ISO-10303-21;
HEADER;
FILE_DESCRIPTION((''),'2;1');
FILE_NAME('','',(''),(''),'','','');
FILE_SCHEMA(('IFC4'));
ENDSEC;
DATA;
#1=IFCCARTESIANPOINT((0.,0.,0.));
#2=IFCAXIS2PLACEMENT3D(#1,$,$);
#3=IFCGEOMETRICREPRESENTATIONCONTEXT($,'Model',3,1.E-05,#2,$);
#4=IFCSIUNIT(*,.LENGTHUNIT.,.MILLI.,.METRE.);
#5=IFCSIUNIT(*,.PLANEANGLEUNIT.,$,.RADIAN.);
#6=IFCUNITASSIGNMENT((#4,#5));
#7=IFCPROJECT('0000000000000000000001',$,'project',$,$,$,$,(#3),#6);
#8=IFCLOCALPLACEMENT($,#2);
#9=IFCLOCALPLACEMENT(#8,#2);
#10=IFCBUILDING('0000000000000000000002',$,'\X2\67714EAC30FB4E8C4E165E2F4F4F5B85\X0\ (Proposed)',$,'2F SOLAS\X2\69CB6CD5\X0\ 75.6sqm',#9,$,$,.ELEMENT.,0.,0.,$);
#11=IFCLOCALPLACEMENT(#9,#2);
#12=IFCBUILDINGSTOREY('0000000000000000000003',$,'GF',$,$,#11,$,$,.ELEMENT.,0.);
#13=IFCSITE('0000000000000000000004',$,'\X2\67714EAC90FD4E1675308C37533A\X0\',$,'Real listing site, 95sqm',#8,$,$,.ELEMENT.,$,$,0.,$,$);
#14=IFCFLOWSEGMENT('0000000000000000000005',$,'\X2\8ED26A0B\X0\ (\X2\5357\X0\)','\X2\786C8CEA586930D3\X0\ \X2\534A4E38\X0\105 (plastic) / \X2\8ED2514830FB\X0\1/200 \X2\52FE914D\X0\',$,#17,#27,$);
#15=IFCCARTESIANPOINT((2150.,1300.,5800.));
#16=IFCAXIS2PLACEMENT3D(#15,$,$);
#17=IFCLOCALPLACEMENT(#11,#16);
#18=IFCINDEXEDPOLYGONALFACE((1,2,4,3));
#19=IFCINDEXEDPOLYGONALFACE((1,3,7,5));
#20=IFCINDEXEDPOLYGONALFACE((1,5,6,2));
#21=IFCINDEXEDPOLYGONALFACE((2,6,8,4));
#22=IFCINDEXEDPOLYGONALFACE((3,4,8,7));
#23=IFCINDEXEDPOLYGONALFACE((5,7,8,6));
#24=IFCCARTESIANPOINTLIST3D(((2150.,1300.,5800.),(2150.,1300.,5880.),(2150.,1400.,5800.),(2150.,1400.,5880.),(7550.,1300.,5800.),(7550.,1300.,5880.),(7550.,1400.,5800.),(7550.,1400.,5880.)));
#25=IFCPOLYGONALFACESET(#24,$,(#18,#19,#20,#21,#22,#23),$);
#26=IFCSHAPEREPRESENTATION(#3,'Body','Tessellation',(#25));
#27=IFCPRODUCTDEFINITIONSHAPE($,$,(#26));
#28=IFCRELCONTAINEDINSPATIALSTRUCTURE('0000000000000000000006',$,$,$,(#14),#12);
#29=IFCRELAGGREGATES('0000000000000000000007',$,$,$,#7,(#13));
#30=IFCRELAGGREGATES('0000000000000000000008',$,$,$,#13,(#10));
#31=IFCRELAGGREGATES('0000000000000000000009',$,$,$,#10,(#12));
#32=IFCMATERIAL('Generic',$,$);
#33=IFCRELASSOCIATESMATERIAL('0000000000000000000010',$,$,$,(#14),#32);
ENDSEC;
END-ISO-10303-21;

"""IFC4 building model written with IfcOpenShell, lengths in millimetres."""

from ifc_helpers import new_model, si_unit, frame, frame_2d, origin, place, context, project, spatial, rectangle, extrude, material, element, save


model = new_model("IFC4")

# Units and contexts
model_context = context("Model", 3, precision=1e-05, world=origin())
ifc_project = project(units=[si_unit("LENGTHUNIT", "METRE", prefix="MILLI"), si_unit("PLANEANGLEUNIT", "RADIAN")], contexts=[model_context])

# Site, building, storey
site_placement = place(None, origin())
site = spatial("IfcSite", under=ifc_project, at=site_placement, Name="東京都世田谷区", ObjectType="Real listing site, 95sqm", CompositionType="ELEMENT", RefElevation=0.0)
building_placement = place(site_placement, origin())
building = spatial("IfcBuilding", under=site, at=building_placement, Name="東京・二世帯住宅 (Proposed)", ObjectType="2F SOLAS構法 75.6sqm", CompositionType="ELEMENT", ElevationOfRefHeight=0.0, ElevationOfTerrain=0.0)
storey_placement = place(building_placement, origin())
storey = spatial("IfcBuildingStorey", under=building, at=storey_placement, Name="GF", CompositionType="ELEMENT", Elevation=0.0)

# Flow segment
ifc_material_1 = material(Name="Generic")
flow_segment_placement = place(storey_placement, frame((2150.0, 1300.0, 5800.0)))
element("IfcFlowSegment", 1, at=flow_segment_placement, inside=storey, material=ifc_material_1, Name="軒樋 (南)", Description="硬質塩ビ 半丸105 (plastic) / 軒先・1/200 勾配", context=model_context, shape_type="SweptSolid", body=[
    extrude(rectangle(XDim=5400.0, YDim=100.0, at=frame_2d((2700.0, 50.0))), frame((2150.0, 1300.0, 5800.0)), (0.0, 0.0, 1.0), 80.0),
])

save(model, "model.ifc")
